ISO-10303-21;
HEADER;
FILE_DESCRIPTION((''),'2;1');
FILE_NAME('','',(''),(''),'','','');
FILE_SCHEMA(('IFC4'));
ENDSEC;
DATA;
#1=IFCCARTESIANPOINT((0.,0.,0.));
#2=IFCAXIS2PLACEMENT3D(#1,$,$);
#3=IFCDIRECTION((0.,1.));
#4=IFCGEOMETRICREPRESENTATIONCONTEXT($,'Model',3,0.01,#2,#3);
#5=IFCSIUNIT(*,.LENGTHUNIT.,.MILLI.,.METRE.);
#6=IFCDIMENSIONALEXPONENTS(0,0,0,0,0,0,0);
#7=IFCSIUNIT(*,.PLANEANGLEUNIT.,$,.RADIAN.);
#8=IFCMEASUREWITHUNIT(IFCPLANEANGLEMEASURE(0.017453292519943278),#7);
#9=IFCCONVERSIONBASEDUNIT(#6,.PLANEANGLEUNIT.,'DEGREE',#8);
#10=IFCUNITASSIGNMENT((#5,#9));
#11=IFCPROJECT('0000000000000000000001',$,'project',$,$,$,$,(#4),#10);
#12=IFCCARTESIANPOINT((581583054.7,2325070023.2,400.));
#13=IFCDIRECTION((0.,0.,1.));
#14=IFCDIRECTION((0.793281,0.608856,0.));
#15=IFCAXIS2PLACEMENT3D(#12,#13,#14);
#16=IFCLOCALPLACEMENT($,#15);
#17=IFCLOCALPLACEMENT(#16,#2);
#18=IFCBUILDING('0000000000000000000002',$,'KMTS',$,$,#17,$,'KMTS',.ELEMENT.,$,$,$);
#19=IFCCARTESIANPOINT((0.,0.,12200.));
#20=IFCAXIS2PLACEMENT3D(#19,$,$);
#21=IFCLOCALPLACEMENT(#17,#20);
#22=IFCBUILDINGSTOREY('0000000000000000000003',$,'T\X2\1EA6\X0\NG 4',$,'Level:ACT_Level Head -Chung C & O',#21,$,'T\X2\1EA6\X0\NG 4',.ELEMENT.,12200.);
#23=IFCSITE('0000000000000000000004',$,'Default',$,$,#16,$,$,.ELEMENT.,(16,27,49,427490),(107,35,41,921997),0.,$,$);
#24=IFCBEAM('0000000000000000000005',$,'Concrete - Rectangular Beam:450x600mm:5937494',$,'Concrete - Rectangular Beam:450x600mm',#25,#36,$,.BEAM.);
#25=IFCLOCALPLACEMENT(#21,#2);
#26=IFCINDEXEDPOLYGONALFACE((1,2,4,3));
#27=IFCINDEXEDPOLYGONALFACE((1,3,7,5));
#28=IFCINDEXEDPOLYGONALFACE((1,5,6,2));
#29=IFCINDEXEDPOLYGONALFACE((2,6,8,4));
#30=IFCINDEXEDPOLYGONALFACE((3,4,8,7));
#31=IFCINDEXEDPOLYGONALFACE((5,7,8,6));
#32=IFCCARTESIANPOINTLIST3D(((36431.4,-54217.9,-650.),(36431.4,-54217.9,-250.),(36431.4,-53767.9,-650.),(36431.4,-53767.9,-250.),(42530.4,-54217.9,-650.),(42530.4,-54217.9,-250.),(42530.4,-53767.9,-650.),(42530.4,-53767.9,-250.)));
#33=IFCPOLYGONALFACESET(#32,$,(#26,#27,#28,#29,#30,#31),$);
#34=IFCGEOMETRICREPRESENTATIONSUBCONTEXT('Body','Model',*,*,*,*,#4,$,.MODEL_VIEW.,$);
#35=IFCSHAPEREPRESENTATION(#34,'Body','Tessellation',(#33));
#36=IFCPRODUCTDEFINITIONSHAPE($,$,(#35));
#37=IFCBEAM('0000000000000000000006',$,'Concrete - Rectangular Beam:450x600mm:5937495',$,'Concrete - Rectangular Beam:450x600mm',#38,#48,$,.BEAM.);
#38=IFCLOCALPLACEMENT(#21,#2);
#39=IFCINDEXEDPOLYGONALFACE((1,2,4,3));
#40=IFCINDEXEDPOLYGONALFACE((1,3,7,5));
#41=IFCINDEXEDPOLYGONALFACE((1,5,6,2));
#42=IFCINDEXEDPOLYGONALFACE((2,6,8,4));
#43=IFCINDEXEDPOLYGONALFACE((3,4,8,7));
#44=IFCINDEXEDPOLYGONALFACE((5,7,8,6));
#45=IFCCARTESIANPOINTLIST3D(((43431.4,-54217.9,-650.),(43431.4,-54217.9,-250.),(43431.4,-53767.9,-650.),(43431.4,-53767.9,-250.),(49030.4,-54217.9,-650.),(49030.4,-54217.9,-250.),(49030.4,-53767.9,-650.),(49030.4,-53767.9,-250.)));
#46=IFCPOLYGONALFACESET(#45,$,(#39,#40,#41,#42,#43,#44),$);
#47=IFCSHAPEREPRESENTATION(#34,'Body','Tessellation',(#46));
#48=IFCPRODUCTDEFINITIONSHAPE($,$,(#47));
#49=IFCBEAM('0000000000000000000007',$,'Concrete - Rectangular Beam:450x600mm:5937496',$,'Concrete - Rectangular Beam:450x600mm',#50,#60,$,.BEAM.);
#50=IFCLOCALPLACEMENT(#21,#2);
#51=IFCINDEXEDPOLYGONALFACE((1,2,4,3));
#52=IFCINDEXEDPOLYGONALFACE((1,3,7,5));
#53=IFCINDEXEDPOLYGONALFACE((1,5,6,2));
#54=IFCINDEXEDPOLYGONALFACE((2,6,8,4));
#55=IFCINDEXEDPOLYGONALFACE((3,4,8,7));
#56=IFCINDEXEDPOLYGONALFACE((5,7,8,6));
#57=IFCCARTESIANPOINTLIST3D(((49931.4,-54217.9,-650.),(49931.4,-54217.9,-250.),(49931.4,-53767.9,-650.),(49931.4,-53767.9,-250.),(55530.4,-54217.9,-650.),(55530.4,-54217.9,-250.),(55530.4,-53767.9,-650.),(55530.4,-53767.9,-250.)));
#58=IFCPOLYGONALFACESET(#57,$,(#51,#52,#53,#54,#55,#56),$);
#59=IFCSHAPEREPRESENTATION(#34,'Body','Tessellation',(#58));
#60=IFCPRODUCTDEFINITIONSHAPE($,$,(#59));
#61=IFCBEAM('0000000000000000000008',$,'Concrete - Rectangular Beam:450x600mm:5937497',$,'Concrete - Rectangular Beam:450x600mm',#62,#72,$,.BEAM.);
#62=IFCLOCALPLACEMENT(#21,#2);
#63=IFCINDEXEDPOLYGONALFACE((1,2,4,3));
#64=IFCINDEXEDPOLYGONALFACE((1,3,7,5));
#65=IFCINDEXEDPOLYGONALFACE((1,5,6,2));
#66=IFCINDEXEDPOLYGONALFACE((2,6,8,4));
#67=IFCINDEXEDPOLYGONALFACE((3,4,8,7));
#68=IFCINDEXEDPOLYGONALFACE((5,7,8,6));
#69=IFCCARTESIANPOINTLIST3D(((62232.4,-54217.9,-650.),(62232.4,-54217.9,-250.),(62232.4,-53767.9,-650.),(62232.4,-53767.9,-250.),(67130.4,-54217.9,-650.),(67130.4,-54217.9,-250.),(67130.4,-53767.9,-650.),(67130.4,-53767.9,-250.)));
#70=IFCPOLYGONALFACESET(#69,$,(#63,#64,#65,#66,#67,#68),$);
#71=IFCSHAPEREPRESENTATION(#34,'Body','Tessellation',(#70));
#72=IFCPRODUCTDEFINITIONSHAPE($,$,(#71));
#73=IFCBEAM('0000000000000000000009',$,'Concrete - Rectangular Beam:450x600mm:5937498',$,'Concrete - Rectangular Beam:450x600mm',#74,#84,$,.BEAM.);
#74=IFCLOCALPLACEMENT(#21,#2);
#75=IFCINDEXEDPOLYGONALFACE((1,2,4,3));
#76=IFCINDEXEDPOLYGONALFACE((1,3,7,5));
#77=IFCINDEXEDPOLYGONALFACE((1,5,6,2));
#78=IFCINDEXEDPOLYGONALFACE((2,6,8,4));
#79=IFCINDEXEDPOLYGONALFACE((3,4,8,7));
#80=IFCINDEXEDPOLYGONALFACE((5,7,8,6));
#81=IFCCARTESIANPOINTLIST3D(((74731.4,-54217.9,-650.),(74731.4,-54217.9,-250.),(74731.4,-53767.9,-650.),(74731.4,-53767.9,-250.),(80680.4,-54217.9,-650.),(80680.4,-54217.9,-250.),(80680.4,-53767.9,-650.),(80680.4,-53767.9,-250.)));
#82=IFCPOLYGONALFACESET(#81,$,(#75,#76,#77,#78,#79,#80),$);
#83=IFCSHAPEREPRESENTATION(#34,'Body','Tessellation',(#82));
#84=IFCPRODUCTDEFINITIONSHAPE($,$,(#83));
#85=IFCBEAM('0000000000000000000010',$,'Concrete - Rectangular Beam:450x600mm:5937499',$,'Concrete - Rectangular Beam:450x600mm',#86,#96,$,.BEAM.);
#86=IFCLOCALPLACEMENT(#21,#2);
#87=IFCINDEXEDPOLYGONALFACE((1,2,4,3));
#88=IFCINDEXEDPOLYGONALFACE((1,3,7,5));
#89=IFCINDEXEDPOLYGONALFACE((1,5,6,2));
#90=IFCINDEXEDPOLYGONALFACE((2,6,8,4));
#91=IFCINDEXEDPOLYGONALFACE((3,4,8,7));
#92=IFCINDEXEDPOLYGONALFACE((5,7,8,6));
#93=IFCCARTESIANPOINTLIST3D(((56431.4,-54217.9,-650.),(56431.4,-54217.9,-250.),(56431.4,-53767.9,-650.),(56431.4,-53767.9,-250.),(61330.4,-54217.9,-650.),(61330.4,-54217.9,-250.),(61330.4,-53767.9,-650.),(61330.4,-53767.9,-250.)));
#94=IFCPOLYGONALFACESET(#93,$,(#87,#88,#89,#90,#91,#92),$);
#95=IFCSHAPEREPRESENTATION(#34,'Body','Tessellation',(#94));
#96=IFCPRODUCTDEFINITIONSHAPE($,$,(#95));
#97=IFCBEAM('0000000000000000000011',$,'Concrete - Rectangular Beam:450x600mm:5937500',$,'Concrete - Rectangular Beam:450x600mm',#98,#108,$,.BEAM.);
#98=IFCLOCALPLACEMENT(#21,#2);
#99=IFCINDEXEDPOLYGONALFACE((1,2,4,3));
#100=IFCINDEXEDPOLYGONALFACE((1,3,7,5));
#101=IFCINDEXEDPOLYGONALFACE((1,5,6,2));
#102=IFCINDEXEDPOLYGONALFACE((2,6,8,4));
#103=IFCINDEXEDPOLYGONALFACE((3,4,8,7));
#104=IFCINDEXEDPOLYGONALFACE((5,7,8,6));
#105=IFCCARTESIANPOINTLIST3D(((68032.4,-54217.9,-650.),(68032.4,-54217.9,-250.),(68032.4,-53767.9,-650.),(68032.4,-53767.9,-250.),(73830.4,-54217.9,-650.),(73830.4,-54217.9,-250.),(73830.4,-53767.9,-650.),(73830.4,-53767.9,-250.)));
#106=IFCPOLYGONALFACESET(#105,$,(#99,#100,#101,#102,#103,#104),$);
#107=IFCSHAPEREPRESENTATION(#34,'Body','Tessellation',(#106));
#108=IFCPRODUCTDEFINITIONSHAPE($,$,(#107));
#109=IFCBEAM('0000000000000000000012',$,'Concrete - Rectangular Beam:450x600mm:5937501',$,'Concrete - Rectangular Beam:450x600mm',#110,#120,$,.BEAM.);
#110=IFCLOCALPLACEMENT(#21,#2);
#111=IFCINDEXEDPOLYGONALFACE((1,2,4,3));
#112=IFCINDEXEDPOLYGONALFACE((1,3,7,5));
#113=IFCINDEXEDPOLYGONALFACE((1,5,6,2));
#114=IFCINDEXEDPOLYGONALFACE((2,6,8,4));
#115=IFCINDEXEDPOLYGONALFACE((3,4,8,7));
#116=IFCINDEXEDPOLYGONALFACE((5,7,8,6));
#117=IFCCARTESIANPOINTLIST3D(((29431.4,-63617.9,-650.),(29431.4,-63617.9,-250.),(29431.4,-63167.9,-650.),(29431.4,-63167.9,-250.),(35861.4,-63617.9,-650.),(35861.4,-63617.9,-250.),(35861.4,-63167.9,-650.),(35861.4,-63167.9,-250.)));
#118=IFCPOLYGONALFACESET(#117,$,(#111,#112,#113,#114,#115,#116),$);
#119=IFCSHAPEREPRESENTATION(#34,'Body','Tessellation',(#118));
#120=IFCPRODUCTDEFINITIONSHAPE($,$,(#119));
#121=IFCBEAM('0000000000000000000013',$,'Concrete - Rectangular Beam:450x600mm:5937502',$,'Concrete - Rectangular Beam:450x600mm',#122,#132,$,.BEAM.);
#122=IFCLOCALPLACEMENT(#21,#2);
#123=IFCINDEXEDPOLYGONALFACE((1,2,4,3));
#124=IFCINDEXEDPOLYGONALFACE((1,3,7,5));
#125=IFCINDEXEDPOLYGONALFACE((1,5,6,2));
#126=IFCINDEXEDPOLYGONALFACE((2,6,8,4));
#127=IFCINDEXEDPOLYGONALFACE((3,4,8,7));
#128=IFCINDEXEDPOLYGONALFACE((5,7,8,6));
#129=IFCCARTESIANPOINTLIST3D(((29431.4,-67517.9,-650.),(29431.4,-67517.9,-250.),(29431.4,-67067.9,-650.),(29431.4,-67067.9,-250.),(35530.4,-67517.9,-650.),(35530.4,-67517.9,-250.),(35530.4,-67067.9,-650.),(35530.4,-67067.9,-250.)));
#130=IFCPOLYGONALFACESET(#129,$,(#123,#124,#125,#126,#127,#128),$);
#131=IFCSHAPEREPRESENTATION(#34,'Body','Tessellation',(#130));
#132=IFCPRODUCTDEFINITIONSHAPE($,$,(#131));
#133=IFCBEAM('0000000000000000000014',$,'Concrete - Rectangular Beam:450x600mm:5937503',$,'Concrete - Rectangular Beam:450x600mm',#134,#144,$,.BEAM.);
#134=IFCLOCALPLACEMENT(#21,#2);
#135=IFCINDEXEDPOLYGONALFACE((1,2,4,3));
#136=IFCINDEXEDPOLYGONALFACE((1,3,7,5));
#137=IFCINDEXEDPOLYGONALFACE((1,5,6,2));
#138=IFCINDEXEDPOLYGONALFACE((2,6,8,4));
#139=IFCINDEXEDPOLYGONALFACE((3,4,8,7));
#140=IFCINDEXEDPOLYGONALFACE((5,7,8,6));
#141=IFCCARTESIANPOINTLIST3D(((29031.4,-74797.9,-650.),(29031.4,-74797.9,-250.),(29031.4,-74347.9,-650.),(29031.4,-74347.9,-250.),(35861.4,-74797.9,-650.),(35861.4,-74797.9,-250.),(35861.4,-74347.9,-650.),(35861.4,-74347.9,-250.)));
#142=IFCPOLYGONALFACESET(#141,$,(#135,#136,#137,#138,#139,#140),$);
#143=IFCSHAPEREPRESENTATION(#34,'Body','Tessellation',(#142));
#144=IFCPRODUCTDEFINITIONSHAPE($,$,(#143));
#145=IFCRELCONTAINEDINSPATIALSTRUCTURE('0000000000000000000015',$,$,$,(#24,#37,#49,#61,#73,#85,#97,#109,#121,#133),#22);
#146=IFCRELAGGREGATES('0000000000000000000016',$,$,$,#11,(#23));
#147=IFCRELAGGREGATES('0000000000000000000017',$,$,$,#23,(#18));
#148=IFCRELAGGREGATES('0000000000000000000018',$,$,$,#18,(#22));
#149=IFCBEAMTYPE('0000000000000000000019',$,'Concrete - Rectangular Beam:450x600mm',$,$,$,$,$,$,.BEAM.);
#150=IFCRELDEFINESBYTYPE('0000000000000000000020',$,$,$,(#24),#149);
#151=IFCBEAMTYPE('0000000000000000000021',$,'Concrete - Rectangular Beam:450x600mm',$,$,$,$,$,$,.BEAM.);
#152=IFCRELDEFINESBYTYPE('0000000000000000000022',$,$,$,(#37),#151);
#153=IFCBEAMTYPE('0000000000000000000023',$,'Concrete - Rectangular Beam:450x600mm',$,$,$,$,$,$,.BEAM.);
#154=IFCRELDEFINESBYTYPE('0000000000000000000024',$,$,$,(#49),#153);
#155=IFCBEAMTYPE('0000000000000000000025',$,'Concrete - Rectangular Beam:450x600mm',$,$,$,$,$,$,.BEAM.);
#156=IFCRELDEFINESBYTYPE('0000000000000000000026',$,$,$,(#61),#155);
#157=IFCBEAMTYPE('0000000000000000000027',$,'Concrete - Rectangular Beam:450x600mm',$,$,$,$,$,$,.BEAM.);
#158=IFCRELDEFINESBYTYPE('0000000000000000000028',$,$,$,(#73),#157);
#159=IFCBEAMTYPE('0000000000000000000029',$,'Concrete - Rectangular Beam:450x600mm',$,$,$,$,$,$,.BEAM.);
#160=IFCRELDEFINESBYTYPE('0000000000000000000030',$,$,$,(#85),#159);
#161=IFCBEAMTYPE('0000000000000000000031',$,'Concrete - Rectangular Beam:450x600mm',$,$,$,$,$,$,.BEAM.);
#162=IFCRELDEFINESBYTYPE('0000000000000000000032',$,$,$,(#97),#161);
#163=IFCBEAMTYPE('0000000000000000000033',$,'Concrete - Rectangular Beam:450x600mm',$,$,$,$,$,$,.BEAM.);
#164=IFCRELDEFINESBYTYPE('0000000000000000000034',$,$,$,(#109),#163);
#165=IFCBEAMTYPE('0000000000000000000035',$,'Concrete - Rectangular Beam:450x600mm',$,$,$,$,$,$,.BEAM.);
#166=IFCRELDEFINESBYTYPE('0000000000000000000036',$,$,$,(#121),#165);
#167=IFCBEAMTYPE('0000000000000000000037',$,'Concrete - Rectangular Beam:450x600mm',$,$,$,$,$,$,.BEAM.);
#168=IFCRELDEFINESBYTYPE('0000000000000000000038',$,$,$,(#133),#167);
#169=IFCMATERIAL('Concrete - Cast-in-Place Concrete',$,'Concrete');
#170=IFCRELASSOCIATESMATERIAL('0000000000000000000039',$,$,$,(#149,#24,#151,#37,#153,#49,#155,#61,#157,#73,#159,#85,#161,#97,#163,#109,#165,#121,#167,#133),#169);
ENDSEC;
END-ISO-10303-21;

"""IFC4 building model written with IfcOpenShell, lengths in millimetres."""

from ifc_helpers import new_model, entity, si_unit, converted_unit, direction, frame, origin, place, context, subcontext, project, spatial, indexed_curve, outline, extrude, source, transform, mapped, material, type_object, type_shapes, element, save


model = new_model("IFC4")

# Units and contexts
model_context = context("Model", 3, precision=0.01, world=origin(), true_north=direction((0.0, 1.0)))
body_context = subcontext(model_context, "Body", "Model", "MODEL_VIEW")
ifc_project = project(units=[si_unit("LENGTHUNIT", "METRE", prefix="MILLI"), converted_unit("PLANEANGLEUNIT", "DEGREE", entity("IfcPlaneAngleMeasure", 0.017453292519943278), si_unit("PLANEANGLEUNIT", "RADIAN"), dimensions=[0, 0, 0, 0, 0, 0, 0])], contexts=[model_context])

# Site, building, storey
site_placement = place(None, frame((581583054.7, 2325070023.2, 400.0), z_axis=(0.0, 0.0, 1.0), x_axis=(0.793281, 0.608856, 0.0)))
site = spatial("IfcSite", under=ifc_project, at=site_placement, Name="Default", CompositionType="ELEMENT", RefLatitude=(16, 27, 49, 427490), RefLongitude=(107, 35, 41, 921997), RefElevation=0.0)
building_placement = place(site_placement, origin())
building = spatial("IfcBuilding", under=site, at=building_placement, Name="KMTS", LongName="KMTS", CompositionType="ELEMENT")
storey_placement = place(building_placement, frame((0.0, 0.0, 12200.0)))
storey = spatial("IfcBuildingStorey", under=building, at=storey_placement, Name="TẦNG 4", ObjectType="Level:ACT_Level Head -Chung C & O", LongName="TẦNG 4", CompositionType="ELEMENT", Elevation=12200.0)

# Beams
ifc_material = material(Name="Concrete - Cast-in-Place Concrete", Category="Concrete")
beam_type_1 = type_object("IfcBeamType", Name="Concrete - Rectangular Beam:450x600mm", PredefinedType="BEAM", material=ifc_material)
shared_shape_1 = source(origin(), body_context, "Body", "SweptSolid", [
    extrude(outline(indexed_curve([(-200.0, -225.0), (200.0, -225.0), (200.0, 225.0), (-200.0, 225.0), (-200.0, -225.0)], self_intersect=False)), frame((36431.4, -53992.9, 11750.0), z_axis=(1.0, 0.0, 0.0), x_axis=(0.0, 0.0, -1.0)), (0.0, 0.0, 1.0), 6099.0),
])
type_shapes(beam_type_1, [shared_shape_1])
beam_1_placement = place(storey_placement, frame((0.0, 0.0, -12200.0)))
element("IfcBeam", 1, at=beam_1_placement, inside=storey, type_object=beam_type_1, material=ifc_material, Name="Concrete - Rectangular Beam:450x600mm:5937494", ObjectType="Concrete - Rectangular Beam:450x600mm", PredefinedType="BEAM", context=body_context, shape_type="MappedRepresentation", body=[
    mapped(shared_shape_1, transform((0.0, 0.0, 0.0), scale=1.0)),
])
beam_type_2 = type_object("IfcBeamType", Name="Concrete - Rectangular Beam:450x600mm", PredefinedType="BEAM", material=ifc_material)
shared_shape_2 = source(origin(), body_context, "Body", "SweptSolid", [
    extrude(outline(indexed_curve([(-200.0, -225.0), (200.0, -225.0), (200.0, 225.0), (-200.0, 225.0), (-200.0, -225.0)], self_intersect=False)), frame((43431.4, -53992.9, 11750.0), z_axis=(1.0, 0.0, 0.0), x_axis=(0.0, 0.0, -1.0)), (0.0, 0.0, 1.0), 5599.0),
])
type_shapes(beam_type_2, [shared_shape_2])
beam_2_placement = place(storey_placement, frame((0.0, 0.0, -12200.0)))
element("IfcBeam", 2, at=beam_2_placement, inside=storey, type_object=beam_type_2, material=ifc_material, Name="Concrete - Rectangular Beam:450x600mm:5937495", ObjectType="Concrete - Rectangular Beam:450x600mm", PredefinedType="BEAM", context=body_context, shape_type="MappedRepresentation", body=[
    mapped(shared_shape_2, transform((0.0, 0.0, 0.0), scale=1.0)),
])
beam_type_3 = type_object("IfcBeamType", Name="Concrete - Rectangular Beam:450x600mm", PredefinedType="BEAM", material=ifc_material)
shared_shape_3 = source(origin(), body_context, "Body", "SweptSolid", [
    extrude(outline(indexed_curve([(-200.0, -225.0), (200.0, -225.0), (200.0, 225.0), (-200.0, 225.0), (-200.0, -225.0)], self_intersect=False)), frame((49931.4, -53992.9, 11750.0), z_axis=(1.0, 0.0, 0.0), x_axis=(0.0, 0.0, -1.0)), (0.0, 0.0, 1.0), 5599.0),
])
type_shapes(beam_type_3, [shared_shape_3])
beam_3_placement = place(storey_placement, frame((0.0, 0.0, -12200.0)))
element("IfcBeam", 3, at=beam_3_placement, inside=storey, type_object=beam_type_3, material=ifc_material, Name="Concrete - Rectangular Beam:450x600mm:5937496", ObjectType="Concrete - Rectangular Beam:450x600mm", PredefinedType="BEAM", context=body_context, shape_type="MappedRepresentation", body=[
    mapped(shared_shape_3, transform((0.0, 0.0, 0.0), scale=1.0)),
])
beam_type_4 = type_object("IfcBeamType", Name="Concrete - Rectangular Beam:450x600mm", PredefinedType="BEAM", material=ifc_material)
shared_shape_4 = source(origin(), body_context, "Body", "SweptSolid", [
    extrude(outline(indexed_curve([(-200.0, -225.0), (200.0, -225.0), (200.0, 225.0), (-200.0, 225.0), (-200.0, -225.0)], self_intersect=False)), frame((62232.4, -53992.9, 11750.0), z_axis=(1.0, 0.0, 0.0), x_axis=(0.0, 0.0, -1.0)), (0.0, 0.0, 1.0), 4898.0),
])
type_shapes(beam_type_4, [shared_shape_4])
beam_4_placement = place(storey_placement, frame((0.0, 0.0, -12200.0)))
element("IfcBeam", 4, at=beam_4_placement, inside=storey, type_object=beam_type_4, material=ifc_material, Name="Concrete - Rectangular Beam:450x600mm:5937497", ObjectType="Concrete - Rectangular Beam:450x600mm", PredefinedType="BEAM", context=body_context, shape_type="MappedRepresentation", body=[
    mapped(shared_shape_4, transform((0.0, 0.0, 0.0), scale=1.0)),
])
beam_type_5 = type_object("IfcBeamType", Name="Concrete - Rectangular Beam:450x600mm", PredefinedType="BEAM", material=ifc_material)
shared_shape_5 = source(origin(), body_context, "Body", "SweptSolid", [
    extrude(outline(indexed_curve([(-200.0, -225.0), (200.0, -225.0), (200.0, 225.0), (-200.0, 225.0), (-200.0, -225.0)], self_intersect=False)), frame((74731.4, -53992.9, 11750.0), z_axis=(1.0, 0.0, 0.0), x_axis=(0.0, 0.0, -1.0)), (0.0, 0.0, 1.0), 5949.0),
])
type_shapes(beam_type_5, [shared_shape_5])
beam_5_placement = place(storey_placement, frame((0.0, 0.0, -12200.0)))
element("IfcBeam", 5, at=beam_5_placement, inside=storey, type_object=beam_type_5, material=ifc_material, Name="Concrete - Rectangular Beam:450x600mm:5937498", ObjectType="Concrete - Rectangular Beam:450x600mm", PredefinedType="BEAM", context=body_context, shape_type="MappedRepresentation", body=[
    mapped(shared_shape_5, transform((0.0, 0.0, 0.0), scale=1.0)),
])
beam_type_6 = type_object("IfcBeamType", Name="Concrete - Rectangular Beam:450x600mm", PredefinedType="BEAM", material=ifc_material)
shared_shape_6 = source(origin(), body_context, "Body", "SweptSolid", [
    extrude(outline(indexed_curve([(-200.0, -225.0), (200.0, -225.0), (200.0, 225.0), (-200.0, 225.0), (-200.0, -225.0)], self_intersect=False)), frame((56431.4, -53992.9, 11750.0), z_axis=(1.0, 0.0, 0.0), x_axis=(0.0, 0.0, -1.0)), (0.0, 0.0, 1.0), 4899.0),
])
type_shapes(beam_type_6, [shared_shape_6])
beam_6_placement = place(storey_placement, frame((0.0, 0.0, -12200.0)))
element("IfcBeam", 6, at=beam_6_placement, inside=storey, type_object=beam_type_6, material=ifc_material, Name="Concrete - Rectangular Beam:450x600mm:5937499", ObjectType="Concrete - Rectangular Beam:450x600mm", PredefinedType="BEAM", context=body_context, shape_type="MappedRepresentation", body=[
    mapped(shared_shape_6, transform((0.0, 0.0, 0.0), scale=1.0)),
])
beam_type_7 = type_object("IfcBeamType", Name="Concrete - Rectangular Beam:450x600mm", PredefinedType="BEAM", material=ifc_material)
shared_shape_7 = source(origin(), body_context, "Body", "SweptSolid", [
    extrude(outline(indexed_curve([(-200.0, -225.0), (200.0, -225.0), (200.0, 225.0), (-200.0, 225.0), (-200.0, -225.0)], self_intersect=False)), frame((68032.4, -53992.9, 11750.0), z_axis=(1.0, 0.0, 0.0), x_axis=(0.0, 0.0, -1.0)), (0.0, 0.0, 1.0), 5798.0),
])
type_shapes(beam_type_7, [shared_shape_7])
beam_7_placement = place(storey_placement, frame((0.0, 0.0, -12200.0)))
element("IfcBeam", 7, at=beam_7_placement, inside=storey, type_object=beam_type_7, material=ifc_material, Name="Concrete - Rectangular Beam:450x600mm:5937500", ObjectType="Concrete - Rectangular Beam:450x600mm", PredefinedType="BEAM", context=body_context, shape_type="MappedRepresentation", body=[
    mapped(shared_shape_7, transform((0.0, 0.0, 0.0), scale=1.0)),
])
beam_type_8 = type_object("IfcBeamType", Name="Concrete - Rectangular Beam:450x600mm", PredefinedType="BEAM", material=ifc_material)
shared_shape_8 = source(origin(), body_context, "Body", "SweptSolid", [
    extrude(outline(indexed_curve([(-200.0, -225.0), (200.0, -225.0), (200.0, 225.0), (-200.0, 225.0), (-200.0, -225.0)], self_intersect=False)), frame((29431.4, -63392.9, 11750.0), z_axis=(1.0, 0.0, 0.0), x_axis=(0.0, 0.0, -1.0)), (0.0, 0.0, 1.0), 6430.0),
])
type_shapes(beam_type_8, [shared_shape_8])
beam_8_placement = place(storey_placement, frame((0.0, 0.0, -12200.0)))
element("IfcBeam", 8, at=beam_8_placement, inside=storey, type_object=beam_type_8, material=ifc_material, Name="Concrete - Rectangular Beam:450x600mm:5937501", ObjectType="Concrete - Rectangular Beam:450x600mm", PredefinedType="BEAM", context=body_context, shape_type="MappedRepresentation", body=[
    mapped(shared_shape_8, transform((0.0, 0.0, 0.0), scale=1.0)),
])
beam_type_9 = type_object("IfcBeamType", Name="Concrete - Rectangular Beam:450x600mm", PredefinedType="BEAM", material=ifc_material)
shared_shape_9 = source(origin(), body_context, "Body", "SweptSolid", [
    extrude(outline(indexed_curve([(-200.0, -225.0), (200.0, -225.0), (200.0, 225.0), (-200.0, 225.0), (-200.0, -225.0)], self_intersect=False)), frame((29431.4, -67292.9, 11750.0), z_axis=(1.0, 0.0, 0.0), x_axis=(0.0, 0.0, -1.0)), (0.0, 0.0, 1.0), 6099.0),
])
type_shapes(beam_type_9, [shared_shape_9])
beam_9_placement = place(storey_placement, frame((0.0, 0.0, -12200.0)))
element("IfcBeam", 9, at=beam_9_placement, inside=storey, type_object=beam_type_9, material=ifc_material, Name="Concrete - Rectangular Beam:450x600mm:5937502", ObjectType="Concrete - Rectangular Beam:450x600mm", PredefinedType="BEAM", context=body_context, shape_type="MappedRepresentation", body=[
    mapped(shared_shape_9, transform((0.0, 0.0, 0.0), scale=1.0)),
])
beam_type_10 = type_object("IfcBeamType", Name="Concrete - Rectangular Beam:450x600mm", PredefinedType="BEAM", material=ifc_material)
shared_shape_10 = source(origin(), body_context, "Body", "SweptSolid", [
    extrude(outline(indexed_curve([(-200.0, -225.0), (200.0, -225.0), (200.0, 225.0), (-200.0, 225.0), (-200.0, -225.0)], self_intersect=False)), frame((29031.4, -74572.9, 11750.0), z_axis=(1.0, 0.0, 0.0), x_axis=(0.0, 0.0, -1.0)), (0.0, 0.0, 1.0), 6830.0),
])
type_shapes(beam_type_10, [shared_shape_10])
beam_10_placement = place(storey_placement, frame((0.0, 0.0, -12200.0)))
element("IfcBeam", 10, at=beam_10_placement, inside=storey, type_object=beam_type_10, material=ifc_material, Name="Concrete - Rectangular Beam:450x600mm:5937503", ObjectType="Concrete - Rectangular Beam:450x600mm", PredefinedType="BEAM", context=body_context, shape_type="MappedRepresentation", body=[
    mapped(shared_shape_10, transform((0.0, 0.0, 0.0), scale=1.0)),
])

save(model, "model.ifc")
